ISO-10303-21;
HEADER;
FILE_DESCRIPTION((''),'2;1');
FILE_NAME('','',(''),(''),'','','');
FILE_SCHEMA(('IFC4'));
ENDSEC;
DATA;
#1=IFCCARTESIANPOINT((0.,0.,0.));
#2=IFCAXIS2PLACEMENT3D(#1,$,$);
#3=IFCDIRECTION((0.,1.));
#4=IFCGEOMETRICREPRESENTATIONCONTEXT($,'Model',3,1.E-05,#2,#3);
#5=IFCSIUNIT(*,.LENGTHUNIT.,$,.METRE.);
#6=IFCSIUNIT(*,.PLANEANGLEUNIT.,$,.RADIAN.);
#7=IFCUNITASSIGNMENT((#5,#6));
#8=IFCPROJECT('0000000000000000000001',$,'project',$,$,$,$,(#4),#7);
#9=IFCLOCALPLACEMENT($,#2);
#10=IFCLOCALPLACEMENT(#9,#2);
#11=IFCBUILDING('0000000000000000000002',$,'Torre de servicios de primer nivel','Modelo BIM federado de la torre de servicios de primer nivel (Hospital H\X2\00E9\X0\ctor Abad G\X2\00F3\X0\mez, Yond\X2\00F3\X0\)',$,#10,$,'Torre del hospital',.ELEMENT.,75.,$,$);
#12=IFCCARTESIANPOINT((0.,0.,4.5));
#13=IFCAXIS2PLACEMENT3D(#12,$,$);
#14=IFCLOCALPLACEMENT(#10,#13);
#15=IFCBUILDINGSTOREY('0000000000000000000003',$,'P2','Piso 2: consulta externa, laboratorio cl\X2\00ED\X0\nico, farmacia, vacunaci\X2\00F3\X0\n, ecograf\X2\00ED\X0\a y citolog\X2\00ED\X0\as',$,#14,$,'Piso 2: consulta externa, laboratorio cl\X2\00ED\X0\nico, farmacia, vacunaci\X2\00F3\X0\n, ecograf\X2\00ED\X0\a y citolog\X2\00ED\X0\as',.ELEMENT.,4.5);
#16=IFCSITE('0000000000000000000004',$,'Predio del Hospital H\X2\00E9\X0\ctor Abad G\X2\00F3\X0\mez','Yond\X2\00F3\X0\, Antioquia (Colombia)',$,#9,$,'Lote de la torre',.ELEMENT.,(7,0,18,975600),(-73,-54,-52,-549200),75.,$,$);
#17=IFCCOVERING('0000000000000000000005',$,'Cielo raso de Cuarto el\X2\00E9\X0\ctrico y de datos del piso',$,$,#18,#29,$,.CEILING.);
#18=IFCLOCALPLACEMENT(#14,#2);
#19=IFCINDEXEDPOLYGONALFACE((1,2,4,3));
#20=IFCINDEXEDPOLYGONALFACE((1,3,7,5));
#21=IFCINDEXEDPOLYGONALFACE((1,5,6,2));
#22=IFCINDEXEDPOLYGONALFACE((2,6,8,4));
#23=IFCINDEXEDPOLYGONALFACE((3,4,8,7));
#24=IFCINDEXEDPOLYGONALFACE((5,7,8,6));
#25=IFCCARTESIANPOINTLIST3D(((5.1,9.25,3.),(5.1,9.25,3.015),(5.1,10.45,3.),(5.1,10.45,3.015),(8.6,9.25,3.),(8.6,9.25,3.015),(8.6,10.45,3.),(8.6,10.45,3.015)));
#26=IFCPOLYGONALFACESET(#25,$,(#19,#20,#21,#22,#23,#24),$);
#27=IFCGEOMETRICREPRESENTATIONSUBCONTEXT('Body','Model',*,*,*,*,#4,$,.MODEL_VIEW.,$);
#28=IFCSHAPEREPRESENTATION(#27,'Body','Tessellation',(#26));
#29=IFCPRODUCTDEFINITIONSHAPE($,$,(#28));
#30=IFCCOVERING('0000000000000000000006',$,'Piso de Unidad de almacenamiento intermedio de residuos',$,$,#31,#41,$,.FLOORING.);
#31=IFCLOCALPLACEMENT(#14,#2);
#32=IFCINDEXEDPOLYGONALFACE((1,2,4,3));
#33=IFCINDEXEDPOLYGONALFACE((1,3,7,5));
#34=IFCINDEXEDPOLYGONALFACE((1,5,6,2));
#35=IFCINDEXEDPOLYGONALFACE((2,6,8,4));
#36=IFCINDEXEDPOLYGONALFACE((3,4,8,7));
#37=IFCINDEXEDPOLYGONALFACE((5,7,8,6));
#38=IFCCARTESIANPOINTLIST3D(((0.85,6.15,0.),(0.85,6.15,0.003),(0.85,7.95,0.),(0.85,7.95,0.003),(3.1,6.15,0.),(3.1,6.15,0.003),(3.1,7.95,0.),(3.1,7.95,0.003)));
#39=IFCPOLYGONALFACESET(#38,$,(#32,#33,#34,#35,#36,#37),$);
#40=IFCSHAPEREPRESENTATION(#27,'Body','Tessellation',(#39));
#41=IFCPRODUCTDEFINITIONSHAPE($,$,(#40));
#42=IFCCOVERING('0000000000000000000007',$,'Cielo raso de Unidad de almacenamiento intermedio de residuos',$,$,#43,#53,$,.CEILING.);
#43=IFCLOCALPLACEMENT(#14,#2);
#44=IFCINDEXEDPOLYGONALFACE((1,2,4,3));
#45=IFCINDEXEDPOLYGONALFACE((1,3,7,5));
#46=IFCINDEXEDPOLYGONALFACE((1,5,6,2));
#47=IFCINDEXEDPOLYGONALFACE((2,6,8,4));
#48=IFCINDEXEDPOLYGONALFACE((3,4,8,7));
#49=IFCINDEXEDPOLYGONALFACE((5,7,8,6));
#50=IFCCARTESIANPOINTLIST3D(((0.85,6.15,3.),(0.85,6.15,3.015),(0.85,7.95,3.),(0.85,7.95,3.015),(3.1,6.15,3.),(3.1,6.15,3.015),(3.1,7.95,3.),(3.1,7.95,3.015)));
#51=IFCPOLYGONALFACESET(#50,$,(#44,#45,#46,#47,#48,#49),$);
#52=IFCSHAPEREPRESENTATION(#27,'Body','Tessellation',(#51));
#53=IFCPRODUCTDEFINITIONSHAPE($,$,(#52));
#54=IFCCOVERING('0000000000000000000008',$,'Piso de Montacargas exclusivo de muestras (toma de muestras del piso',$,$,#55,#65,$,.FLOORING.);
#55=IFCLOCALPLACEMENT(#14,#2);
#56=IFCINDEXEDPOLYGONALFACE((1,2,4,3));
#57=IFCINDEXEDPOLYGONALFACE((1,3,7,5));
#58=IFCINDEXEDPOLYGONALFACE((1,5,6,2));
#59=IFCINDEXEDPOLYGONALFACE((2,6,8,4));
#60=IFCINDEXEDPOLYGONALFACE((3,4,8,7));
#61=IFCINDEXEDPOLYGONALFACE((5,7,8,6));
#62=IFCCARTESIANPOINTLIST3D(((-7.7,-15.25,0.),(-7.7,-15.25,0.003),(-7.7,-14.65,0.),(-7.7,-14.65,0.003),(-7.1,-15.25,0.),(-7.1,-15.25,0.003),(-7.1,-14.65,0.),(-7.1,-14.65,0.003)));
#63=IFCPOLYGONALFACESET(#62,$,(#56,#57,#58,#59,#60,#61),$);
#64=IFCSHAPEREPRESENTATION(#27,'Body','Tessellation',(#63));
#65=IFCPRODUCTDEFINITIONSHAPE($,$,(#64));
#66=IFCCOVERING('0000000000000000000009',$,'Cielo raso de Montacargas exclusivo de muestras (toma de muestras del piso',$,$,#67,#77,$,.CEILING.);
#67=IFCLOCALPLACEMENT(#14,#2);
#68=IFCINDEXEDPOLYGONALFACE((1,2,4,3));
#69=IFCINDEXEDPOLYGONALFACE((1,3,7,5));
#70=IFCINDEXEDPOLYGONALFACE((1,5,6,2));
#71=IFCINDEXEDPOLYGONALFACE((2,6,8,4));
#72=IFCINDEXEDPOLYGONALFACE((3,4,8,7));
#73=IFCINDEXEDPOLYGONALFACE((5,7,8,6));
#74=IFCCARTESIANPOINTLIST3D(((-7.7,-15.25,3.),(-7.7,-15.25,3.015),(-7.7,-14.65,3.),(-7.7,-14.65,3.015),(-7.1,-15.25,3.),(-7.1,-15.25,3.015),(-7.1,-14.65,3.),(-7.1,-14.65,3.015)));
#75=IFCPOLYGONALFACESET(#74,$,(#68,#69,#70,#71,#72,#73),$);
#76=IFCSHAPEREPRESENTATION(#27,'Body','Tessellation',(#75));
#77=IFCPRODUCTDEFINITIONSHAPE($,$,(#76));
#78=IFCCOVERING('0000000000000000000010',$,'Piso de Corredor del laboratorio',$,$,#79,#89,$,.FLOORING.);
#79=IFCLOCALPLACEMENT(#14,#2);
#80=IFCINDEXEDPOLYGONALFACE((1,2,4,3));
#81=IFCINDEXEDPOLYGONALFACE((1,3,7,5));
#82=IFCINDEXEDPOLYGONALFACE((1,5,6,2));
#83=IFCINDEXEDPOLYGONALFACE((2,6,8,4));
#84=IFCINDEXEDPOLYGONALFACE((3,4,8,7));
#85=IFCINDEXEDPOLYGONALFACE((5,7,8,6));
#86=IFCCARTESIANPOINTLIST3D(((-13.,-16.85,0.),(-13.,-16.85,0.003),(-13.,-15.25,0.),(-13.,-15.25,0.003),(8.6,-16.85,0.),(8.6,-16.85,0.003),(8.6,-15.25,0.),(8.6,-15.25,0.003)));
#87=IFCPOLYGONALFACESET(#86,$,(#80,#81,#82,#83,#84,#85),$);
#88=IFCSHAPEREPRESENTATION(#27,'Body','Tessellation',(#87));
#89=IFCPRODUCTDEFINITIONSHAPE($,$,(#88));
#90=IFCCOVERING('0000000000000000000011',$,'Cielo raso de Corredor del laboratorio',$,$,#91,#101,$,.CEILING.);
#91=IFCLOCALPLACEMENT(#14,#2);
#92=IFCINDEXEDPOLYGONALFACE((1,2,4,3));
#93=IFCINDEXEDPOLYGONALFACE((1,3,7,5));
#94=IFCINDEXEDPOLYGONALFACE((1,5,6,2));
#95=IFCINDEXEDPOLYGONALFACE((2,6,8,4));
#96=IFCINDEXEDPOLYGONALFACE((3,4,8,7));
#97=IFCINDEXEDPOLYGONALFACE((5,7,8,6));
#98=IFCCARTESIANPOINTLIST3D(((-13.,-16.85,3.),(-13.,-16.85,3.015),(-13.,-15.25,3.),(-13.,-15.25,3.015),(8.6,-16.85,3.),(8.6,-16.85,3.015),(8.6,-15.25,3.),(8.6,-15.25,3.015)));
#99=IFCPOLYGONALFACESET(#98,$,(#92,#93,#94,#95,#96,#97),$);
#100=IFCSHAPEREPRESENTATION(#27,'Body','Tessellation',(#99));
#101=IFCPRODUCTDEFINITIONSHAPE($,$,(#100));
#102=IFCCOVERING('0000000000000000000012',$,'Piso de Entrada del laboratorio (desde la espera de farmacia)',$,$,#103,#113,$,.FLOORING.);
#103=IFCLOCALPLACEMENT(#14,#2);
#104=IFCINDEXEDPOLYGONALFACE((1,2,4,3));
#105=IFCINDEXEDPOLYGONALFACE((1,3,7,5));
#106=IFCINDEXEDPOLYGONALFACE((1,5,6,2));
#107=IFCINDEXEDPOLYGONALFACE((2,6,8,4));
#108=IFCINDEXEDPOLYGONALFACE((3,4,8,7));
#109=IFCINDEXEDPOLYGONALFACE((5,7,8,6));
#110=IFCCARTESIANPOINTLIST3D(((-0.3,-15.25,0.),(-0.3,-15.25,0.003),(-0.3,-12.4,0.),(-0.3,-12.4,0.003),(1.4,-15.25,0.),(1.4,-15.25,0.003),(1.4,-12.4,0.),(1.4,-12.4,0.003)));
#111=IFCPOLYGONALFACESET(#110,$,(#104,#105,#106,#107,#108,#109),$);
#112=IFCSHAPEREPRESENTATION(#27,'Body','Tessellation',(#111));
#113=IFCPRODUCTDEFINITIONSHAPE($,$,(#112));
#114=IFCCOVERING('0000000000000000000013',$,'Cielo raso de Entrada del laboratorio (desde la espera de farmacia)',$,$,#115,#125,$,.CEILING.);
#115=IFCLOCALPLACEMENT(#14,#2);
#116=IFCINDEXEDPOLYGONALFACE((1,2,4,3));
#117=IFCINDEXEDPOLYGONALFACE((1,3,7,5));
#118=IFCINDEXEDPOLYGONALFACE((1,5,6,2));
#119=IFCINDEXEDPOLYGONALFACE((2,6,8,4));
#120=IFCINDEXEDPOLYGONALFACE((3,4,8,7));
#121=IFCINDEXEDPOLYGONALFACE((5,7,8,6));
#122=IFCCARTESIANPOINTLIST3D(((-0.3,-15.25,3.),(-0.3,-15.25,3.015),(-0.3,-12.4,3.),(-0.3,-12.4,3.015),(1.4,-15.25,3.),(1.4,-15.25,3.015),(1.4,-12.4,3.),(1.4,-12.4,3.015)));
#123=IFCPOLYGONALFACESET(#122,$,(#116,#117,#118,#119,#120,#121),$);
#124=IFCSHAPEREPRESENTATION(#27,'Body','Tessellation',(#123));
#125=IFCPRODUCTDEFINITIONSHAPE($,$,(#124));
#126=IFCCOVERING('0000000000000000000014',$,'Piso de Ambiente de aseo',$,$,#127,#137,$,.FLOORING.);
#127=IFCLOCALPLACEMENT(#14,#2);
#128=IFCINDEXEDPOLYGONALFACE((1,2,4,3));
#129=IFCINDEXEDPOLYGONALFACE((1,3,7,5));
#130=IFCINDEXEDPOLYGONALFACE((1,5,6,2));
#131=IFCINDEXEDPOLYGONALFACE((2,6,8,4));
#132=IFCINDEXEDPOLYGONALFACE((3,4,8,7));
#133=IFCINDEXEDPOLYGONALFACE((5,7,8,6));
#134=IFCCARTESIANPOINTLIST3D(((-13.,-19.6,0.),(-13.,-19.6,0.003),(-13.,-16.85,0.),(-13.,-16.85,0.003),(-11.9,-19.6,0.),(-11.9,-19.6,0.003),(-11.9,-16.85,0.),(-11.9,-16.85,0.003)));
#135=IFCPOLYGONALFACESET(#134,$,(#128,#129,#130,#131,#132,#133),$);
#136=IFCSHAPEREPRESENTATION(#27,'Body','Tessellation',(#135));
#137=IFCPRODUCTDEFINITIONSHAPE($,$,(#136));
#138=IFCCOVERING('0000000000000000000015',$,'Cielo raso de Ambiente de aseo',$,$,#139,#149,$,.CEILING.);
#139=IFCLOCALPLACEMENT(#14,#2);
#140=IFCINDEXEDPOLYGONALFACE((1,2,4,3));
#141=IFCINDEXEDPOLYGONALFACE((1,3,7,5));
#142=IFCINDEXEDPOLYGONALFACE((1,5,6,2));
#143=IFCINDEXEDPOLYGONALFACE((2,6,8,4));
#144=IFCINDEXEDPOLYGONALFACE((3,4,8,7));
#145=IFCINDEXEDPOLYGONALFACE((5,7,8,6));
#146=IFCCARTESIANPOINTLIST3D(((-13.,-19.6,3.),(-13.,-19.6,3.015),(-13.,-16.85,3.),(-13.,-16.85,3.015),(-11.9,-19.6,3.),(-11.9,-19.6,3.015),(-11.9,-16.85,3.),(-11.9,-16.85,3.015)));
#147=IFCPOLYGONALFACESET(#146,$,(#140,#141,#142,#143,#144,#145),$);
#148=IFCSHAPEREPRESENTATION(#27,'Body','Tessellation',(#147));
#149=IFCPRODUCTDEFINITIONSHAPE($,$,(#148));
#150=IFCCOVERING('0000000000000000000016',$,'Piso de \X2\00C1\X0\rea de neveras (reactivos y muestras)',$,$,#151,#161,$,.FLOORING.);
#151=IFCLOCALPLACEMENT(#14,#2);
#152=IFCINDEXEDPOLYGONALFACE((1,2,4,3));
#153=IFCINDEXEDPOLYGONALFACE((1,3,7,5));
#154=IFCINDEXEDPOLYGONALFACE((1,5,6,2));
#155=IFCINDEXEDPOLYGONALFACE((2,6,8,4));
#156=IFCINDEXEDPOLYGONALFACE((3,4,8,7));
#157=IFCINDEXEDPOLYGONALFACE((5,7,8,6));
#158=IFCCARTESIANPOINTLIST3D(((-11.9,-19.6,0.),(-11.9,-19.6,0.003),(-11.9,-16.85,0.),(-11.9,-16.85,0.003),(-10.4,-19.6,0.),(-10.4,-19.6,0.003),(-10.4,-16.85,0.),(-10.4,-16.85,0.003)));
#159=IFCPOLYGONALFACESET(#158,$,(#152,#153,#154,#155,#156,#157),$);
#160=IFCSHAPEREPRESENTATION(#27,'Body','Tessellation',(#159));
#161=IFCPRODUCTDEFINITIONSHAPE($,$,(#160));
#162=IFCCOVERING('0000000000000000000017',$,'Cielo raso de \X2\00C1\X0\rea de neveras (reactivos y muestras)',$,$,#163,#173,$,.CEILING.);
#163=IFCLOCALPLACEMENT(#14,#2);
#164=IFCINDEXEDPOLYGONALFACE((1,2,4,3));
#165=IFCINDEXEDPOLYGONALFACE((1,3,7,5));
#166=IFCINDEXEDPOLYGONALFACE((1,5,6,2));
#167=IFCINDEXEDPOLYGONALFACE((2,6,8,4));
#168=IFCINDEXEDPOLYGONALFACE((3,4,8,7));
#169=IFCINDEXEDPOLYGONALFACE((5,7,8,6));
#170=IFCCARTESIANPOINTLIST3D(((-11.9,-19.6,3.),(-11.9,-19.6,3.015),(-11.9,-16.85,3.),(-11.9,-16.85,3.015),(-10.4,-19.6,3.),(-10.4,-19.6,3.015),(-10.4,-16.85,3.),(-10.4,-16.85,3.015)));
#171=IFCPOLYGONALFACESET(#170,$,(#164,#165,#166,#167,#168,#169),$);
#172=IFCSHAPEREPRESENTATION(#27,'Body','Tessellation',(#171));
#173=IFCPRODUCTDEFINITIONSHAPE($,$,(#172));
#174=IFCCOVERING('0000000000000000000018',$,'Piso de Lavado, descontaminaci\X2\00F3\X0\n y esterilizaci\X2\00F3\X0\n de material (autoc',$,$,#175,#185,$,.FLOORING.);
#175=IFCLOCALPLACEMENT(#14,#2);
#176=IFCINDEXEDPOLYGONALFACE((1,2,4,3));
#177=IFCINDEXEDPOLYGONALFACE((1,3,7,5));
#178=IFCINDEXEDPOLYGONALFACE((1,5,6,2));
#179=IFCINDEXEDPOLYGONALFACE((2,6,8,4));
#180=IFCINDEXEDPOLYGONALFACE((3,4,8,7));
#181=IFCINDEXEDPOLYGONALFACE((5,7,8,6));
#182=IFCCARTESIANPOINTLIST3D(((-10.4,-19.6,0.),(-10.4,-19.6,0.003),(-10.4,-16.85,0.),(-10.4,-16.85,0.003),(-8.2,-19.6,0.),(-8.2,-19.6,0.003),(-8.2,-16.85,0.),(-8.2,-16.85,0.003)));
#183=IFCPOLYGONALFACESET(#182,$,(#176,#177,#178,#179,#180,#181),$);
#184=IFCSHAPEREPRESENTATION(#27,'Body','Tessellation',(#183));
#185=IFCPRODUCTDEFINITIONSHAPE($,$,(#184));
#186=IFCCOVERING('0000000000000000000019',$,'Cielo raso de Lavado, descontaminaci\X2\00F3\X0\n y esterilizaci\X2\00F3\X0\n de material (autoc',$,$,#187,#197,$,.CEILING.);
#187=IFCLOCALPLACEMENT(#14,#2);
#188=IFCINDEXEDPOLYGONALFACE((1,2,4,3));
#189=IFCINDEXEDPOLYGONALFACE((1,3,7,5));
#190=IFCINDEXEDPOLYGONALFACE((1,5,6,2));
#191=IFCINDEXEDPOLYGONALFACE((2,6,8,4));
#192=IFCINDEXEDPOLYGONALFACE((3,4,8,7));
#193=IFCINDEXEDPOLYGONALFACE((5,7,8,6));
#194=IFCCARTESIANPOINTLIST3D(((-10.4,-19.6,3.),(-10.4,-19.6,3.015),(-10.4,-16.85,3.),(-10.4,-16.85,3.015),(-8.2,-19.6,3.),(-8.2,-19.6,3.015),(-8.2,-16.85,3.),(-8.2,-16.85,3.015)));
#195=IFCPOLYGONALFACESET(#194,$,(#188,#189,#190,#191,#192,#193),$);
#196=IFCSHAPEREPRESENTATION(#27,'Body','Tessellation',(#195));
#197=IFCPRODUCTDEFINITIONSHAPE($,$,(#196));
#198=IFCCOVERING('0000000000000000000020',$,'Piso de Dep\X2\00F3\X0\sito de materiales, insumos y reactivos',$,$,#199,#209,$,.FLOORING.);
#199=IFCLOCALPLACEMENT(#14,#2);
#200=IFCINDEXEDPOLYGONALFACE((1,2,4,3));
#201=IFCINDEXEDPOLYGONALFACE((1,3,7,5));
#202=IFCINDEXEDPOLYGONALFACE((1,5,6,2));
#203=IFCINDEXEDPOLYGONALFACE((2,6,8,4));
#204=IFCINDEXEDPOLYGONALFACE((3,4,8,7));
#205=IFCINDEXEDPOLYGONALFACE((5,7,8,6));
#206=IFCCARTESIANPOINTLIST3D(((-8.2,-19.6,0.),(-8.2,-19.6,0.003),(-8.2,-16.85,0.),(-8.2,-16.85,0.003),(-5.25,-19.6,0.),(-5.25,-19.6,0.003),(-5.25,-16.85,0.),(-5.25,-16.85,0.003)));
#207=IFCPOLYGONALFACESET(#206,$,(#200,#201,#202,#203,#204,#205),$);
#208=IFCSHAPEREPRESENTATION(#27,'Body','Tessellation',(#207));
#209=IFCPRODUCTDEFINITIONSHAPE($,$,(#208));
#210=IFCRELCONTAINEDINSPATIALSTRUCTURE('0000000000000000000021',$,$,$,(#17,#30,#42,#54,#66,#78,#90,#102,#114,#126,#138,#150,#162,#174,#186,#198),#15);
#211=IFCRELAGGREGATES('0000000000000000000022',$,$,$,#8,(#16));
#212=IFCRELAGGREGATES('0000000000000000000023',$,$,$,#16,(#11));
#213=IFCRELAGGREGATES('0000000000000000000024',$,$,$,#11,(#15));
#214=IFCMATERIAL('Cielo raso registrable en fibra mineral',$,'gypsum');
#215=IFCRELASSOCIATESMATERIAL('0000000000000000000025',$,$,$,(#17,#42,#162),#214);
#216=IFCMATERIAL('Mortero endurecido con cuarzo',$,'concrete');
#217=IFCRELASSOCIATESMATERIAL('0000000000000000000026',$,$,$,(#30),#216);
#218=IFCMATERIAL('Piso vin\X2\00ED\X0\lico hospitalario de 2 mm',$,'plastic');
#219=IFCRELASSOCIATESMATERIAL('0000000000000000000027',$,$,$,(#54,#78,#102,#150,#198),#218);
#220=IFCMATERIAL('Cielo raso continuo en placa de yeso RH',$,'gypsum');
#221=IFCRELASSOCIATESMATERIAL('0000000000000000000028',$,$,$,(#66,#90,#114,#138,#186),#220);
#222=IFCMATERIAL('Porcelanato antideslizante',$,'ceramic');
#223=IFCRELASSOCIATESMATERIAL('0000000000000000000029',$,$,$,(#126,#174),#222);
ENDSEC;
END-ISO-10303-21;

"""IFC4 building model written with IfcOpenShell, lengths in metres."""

from ifc_helpers import new_model, si_unit, direction, frame, origin, place, context, subcontext, project, spatial, indexed_curve, outline, extrude, material, element, save


model = new_model("IFC4")

# Units and contexts
model_context = context("Model", 3, precision=1e-05, world=origin(), true_north=direction((0.0, 1.0)))
body_context = subcontext(model_context, "Body", "Model", "MODEL_VIEW")
ifc_project = project(units=[si_unit("LENGTHUNIT", "METRE"), si_unit("PLANEANGLEUNIT", "RADIAN")], contexts=[model_context])

# Site, building, storey
site_placement = place(None, origin())
site = spatial("IfcSite", under=ifc_project, at=site_placement, Name="Predio del Hospital Héctor Abad Gómez", Description="Yondó, Antioquia (Colombia)", LongName="Lote de la torre", CompositionType="ELEMENT", RefLatitude=(7, 0, 18, 975600), RefLongitude=(-73, -54, -52, -549200), RefElevation=75.0)
building_placement = place(site_placement, origin())
building = spatial("IfcBuilding", under=site, at=building_placement, Name="Torre de servicios de primer nivel", Description="Modelo BIM federado de la torre de servicios de primer nivel (Hospital Héctor Abad Gómez, Yondó)", LongName="Torre del hospital", CompositionType="ELEMENT", ElevationOfRefHeight=75.0)
placement = place(building_placement, frame((0.0, 0.0, 4.5)))
storey = spatial("IfcBuildingStorey", under=building, at=placement, Name="P2", Description="Piso 2: consulta externa, laboratorio clínico, farmacia, vacunación, ecografía y citologías", LongName="Piso 2: consulta externa, laboratorio clínico, farmacia, vacunación, ecografía y citologías", CompositionType="ELEMENT", Elevation=4.5)

# Coverings
ifc_material_1 = material(Name="Cielo raso registrable en fibra mineral", Category="gypsum")
element("IfcCovering", 1, at=placement, inside=storey, material=ifc_material_1, Name="Cielo raso de Cuarto eléctrico y de datos del piso", PredefinedType="CEILING", context=body_context, shape_type="SweptSolid", body=[
    extrude(outline(indexed_curve([(5.1, 9.25), (8.6, 9.25), (8.6, 10.45), (5.1, 10.45), (5.1, 9.25)], self_intersect=False)), frame((0.0, 0.0, 3.0)), (0.0, 0.0, 1.0), 0.015),
])
ifc_material_2 = material(Name="Mortero endurecido con cuarzo", Category="concrete")
element("IfcCovering", 2, at=placement, inside=storey, material=ifc_material_2, Name="Piso de Unidad de almacenamiento intermedio de residuos", PredefinedType="FLOORING", context=body_context, shape_type="SweptSolid", body=[
    extrude(outline(indexed_curve([(0.85, 6.15), (3.1, 6.15), (3.1, 7.95), (0.85, 7.95), (0.85, 6.15)], self_intersect=False)), origin(), (0.0, 0.0, 1.0), 0.003),
])
element("IfcCovering", 3, at=placement, inside=storey, material=ifc_material_1, Name="Cielo raso de Unidad de almacenamiento intermedio de residuos", PredefinedType="CEILING", context=body_context, shape_type="SweptSolid", body=[
    extrude(outline(indexed_curve([(0.85, 6.15), (3.1, 6.15), (3.1, 7.95), (0.85, 7.95), (0.85, 6.15)], self_intersect=False)), frame((0.0, 0.0, 3.0)), (0.0, 0.0, 1.0), 0.015),
])
ifc_material_3 = material(Name="Piso vinílico hospitalario de 2 mm", Category="plastic")
element("IfcCovering", 4, at=placement, inside=storey, material=ifc_material_3, Name="Piso de Montacargas exclusivo de muestras (toma de muestras del piso", PredefinedType="FLOORING", context=body_context, shape_type="SweptSolid", body=[
    extrude(outline(indexed_curve([(-7.7, -15.25), (-7.1, -15.25), (-7.1, -14.65), (-7.7, -14.65), (-7.7, -15.25)], self_intersect=False)), origin(), (0.0, 0.0, 1.0), 0.003),
])
ifc_material_4 = material(Name="Cielo raso continuo en placa de yeso RH", Category="gypsum")
element("IfcCovering", 5, at=placement, inside=storey, material=ifc_material_4, Name="Cielo raso de Montacargas exclusivo de muestras (toma de muestras del piso", PredefinedType="CEILING", context=body_context, shape_type="SweptSolid", body=[
    extrude(outline(indexed_curve([(-7.7, -15.25), (-7.1, -15.25), (-7.1, -14.65), (-7.7, -14.65), (-7.7, -15.25)], self_intersect=False)), frame((0.0, 0.0, 3.0)), (0.0, 0.0, 1.0), 0.015),
])
element("IfcCovering", 6, at=placement, inside=storey, material=ifc_material_3, Name="Piso de Corredor del laboratorio", PredefinedType="FLOORING", context=body_context, shape_type="SweptSolid", body=[
    extrude(outline(indexed_curve([(-13.0, -16.85), (8.6, -16.85), (8.6, -15.25), (-13.0, -15.25), (-13.0, -16.85)], self_intersect=False)), origin(), (0.0, 0.0, 1.0), 0.003),
])
element("IfcCovering", 7, at=placement, inside=storey, material=ifc_material_4, Name="Cielo raso de Corredor del laboratorio", PredefinedType="CEILING", context=body_context, shape_type="SweptSolid", body=[
    extrude(outline(indexed_curve([(-13.0, -16.85), (8.6, -16.85), (8.6, -15.25), (-13.0, -15.25), (-13.0, -16.85)], self_intersect=False)), frame((0.0, 0.0, 3.0)), (0.0, 0.0, 1.0), 0.015),
])
element("IfcCovering", 8, at=placement, inside=storey, material=ifc_material_3, Name="Piso de Entrada del laboratorio (desde la espera de farmacia)", PredefinedType="FLOORING", context=body_context, shape_type="SweptSolid", body=[
    extrude(outline(indexed_curve([(-0.3, -15.25), (1.4, -15.25), (1.4, -12.4), (-0.3, -12.4), (-0.3, -15.25)], self_intersect=False)), origin(), (0.0, 0.0, 1.0), 0.003),
])
element("IfcCovering", 9, at=placement, inside=storey, material=ifc_material_4, Name="Cielo raso de Entrada del laboratorio (desde la espera de farmacia)", PredefinedType="CEILING", context=body_context, shape_type="SweptSolid", body=[
    extrude(outline(indexed_curve([(-0.3, -15.25), (1.4, -15.25), (1.4, -12.4), (-0.3, -12.4), (-0.3, -15.25)], self_intersect=False)), frame((0.0, 0.0, 3.0)), (0.0, 0.0, 1.0), 0.015),
])
ifc_material_5 = material(Name="Porcelanato antideslizante", Category="ceramic")
element("IfcCovering", 10, at=placement, inside=storey, material=ifc_material_5, Name="Piso de Ambiente de aseo", PredefinedType="FLOORING", context=body_context, shape_type="SweptSolid", body=[
    extrude(outline(indexed_curve([(-13.0, -19.6), (-11.9, -19.6), (-11.9, -16.85), (-13.0, -16.85), (-13.0, -19.6)], self_intersect=False)), origin(), (0.0, 0.0, 1.0), 0.003),
])
element("IfcCovering", 11, at=placement, inside=storey, material=ifc_material_4, Name="Cielo raso de Ambiente de aseo", PredefinedType="CEILING", context=body_context, shape_type="SweptSolid", body=[
    extrude(outline(indexed_curve([(-13.0, -19.6), (-11.9, -19.6), (-11.9, -16.85), (-13.0, -16.85), (-13.0, -19.6)], self_intersect=False)), frame((0.0, 0.0, 3.0)), (0.0, 0.0, 1.0), 0.015),
])
element("IfcCovering", 12, at=placement, inside=storey, material=ifc_material_3, Name="Piso de Área de neveras (reactivos y muestras)", PredefinedType="FLOORING", context=body_context, shape_type="SweptSolid", body=[
    extrude(outline(indexed_curve([(-11.9, -19.6), (-10.4, -19.6), (-10.4, -16.85), (-11.9, -16.85), (-11.9, -19.6)], self_intersect=False)), origin(), (0.0, 0.0, 1.0), 0.003),
])
element("IfcCovering", 13, at=placement, inside=storey, material=ifc_material_1, Name="Cielo raso de Área de neveras (reactivos y muestras)", PredefinedType="CEILING", context=body_context, shape_type="SweptSolid", body=[
    extrude(outline(indexed_curve([(-11.9, -19.6), (-10.4, -19.6), (-10.4, -16.85), (-11.9, -16.85), (-11.9, -19.6)], self_intersect=False)), frame((0.0, 0.0, 3.0)), (0.0, 0.0, 1.0), 0.015),
])
element("IfcCovering", 14, at=placement, inside=storey, material=ifc_material_5, Name="Piso de Lavado, descontaminación y esterilización de material (autoc", PredefinedType="FLOORING", context=body_context, shape_type="SweptSolid", body=[
    extrude(outline(indexed_curve([(-10.4, -19.6), (-8.2, -19.6), (-8.2, -16.85), (-10.4, -16.85), (-10.4, -19.6)], self_intersect=False)), origin(), (0.0, 0.0, 1.0), 0.003),
])
element("IfcCovering", 15, at=placement, inside=storey, material=ifc_material_4, Name="Cielo raso de Lavado, descontaminación y esterilización de material (autoc", PredefinedType="CEILING", context=body_context, shape_type="SweptSolid", body=[
    extrude(outline(indexed_curve([(-10.4, -19.6), (-8.2, -19.6), (-8.2, -16.85), (-10.4, -16.85), (-10.4, -19.6)], self_intersect=False)), frame((0.0, 0.0, 3.0)), (0.0, 0.0, 1.0), 0.015),
])
element("IfcCovering", 16, at=placement, inside=storey, material=ifc_material_3, Name="Piso de Depósito de materiales, insumos y reactivos", PredefinedType="FLOORING", context=body_context, shape_type="SweptSolid", body=[
    extrude(outline(indexed_curve([(-8.2, -19.6), (-5.25, -19.6), (-5.25, -16.85), (-8.2, -16.85), (-8.2, -19.6)], self_intersect=False)), origin(), (0.0, 0.0, 1.0), 0.003),
])

save(model, "model.ifc")
